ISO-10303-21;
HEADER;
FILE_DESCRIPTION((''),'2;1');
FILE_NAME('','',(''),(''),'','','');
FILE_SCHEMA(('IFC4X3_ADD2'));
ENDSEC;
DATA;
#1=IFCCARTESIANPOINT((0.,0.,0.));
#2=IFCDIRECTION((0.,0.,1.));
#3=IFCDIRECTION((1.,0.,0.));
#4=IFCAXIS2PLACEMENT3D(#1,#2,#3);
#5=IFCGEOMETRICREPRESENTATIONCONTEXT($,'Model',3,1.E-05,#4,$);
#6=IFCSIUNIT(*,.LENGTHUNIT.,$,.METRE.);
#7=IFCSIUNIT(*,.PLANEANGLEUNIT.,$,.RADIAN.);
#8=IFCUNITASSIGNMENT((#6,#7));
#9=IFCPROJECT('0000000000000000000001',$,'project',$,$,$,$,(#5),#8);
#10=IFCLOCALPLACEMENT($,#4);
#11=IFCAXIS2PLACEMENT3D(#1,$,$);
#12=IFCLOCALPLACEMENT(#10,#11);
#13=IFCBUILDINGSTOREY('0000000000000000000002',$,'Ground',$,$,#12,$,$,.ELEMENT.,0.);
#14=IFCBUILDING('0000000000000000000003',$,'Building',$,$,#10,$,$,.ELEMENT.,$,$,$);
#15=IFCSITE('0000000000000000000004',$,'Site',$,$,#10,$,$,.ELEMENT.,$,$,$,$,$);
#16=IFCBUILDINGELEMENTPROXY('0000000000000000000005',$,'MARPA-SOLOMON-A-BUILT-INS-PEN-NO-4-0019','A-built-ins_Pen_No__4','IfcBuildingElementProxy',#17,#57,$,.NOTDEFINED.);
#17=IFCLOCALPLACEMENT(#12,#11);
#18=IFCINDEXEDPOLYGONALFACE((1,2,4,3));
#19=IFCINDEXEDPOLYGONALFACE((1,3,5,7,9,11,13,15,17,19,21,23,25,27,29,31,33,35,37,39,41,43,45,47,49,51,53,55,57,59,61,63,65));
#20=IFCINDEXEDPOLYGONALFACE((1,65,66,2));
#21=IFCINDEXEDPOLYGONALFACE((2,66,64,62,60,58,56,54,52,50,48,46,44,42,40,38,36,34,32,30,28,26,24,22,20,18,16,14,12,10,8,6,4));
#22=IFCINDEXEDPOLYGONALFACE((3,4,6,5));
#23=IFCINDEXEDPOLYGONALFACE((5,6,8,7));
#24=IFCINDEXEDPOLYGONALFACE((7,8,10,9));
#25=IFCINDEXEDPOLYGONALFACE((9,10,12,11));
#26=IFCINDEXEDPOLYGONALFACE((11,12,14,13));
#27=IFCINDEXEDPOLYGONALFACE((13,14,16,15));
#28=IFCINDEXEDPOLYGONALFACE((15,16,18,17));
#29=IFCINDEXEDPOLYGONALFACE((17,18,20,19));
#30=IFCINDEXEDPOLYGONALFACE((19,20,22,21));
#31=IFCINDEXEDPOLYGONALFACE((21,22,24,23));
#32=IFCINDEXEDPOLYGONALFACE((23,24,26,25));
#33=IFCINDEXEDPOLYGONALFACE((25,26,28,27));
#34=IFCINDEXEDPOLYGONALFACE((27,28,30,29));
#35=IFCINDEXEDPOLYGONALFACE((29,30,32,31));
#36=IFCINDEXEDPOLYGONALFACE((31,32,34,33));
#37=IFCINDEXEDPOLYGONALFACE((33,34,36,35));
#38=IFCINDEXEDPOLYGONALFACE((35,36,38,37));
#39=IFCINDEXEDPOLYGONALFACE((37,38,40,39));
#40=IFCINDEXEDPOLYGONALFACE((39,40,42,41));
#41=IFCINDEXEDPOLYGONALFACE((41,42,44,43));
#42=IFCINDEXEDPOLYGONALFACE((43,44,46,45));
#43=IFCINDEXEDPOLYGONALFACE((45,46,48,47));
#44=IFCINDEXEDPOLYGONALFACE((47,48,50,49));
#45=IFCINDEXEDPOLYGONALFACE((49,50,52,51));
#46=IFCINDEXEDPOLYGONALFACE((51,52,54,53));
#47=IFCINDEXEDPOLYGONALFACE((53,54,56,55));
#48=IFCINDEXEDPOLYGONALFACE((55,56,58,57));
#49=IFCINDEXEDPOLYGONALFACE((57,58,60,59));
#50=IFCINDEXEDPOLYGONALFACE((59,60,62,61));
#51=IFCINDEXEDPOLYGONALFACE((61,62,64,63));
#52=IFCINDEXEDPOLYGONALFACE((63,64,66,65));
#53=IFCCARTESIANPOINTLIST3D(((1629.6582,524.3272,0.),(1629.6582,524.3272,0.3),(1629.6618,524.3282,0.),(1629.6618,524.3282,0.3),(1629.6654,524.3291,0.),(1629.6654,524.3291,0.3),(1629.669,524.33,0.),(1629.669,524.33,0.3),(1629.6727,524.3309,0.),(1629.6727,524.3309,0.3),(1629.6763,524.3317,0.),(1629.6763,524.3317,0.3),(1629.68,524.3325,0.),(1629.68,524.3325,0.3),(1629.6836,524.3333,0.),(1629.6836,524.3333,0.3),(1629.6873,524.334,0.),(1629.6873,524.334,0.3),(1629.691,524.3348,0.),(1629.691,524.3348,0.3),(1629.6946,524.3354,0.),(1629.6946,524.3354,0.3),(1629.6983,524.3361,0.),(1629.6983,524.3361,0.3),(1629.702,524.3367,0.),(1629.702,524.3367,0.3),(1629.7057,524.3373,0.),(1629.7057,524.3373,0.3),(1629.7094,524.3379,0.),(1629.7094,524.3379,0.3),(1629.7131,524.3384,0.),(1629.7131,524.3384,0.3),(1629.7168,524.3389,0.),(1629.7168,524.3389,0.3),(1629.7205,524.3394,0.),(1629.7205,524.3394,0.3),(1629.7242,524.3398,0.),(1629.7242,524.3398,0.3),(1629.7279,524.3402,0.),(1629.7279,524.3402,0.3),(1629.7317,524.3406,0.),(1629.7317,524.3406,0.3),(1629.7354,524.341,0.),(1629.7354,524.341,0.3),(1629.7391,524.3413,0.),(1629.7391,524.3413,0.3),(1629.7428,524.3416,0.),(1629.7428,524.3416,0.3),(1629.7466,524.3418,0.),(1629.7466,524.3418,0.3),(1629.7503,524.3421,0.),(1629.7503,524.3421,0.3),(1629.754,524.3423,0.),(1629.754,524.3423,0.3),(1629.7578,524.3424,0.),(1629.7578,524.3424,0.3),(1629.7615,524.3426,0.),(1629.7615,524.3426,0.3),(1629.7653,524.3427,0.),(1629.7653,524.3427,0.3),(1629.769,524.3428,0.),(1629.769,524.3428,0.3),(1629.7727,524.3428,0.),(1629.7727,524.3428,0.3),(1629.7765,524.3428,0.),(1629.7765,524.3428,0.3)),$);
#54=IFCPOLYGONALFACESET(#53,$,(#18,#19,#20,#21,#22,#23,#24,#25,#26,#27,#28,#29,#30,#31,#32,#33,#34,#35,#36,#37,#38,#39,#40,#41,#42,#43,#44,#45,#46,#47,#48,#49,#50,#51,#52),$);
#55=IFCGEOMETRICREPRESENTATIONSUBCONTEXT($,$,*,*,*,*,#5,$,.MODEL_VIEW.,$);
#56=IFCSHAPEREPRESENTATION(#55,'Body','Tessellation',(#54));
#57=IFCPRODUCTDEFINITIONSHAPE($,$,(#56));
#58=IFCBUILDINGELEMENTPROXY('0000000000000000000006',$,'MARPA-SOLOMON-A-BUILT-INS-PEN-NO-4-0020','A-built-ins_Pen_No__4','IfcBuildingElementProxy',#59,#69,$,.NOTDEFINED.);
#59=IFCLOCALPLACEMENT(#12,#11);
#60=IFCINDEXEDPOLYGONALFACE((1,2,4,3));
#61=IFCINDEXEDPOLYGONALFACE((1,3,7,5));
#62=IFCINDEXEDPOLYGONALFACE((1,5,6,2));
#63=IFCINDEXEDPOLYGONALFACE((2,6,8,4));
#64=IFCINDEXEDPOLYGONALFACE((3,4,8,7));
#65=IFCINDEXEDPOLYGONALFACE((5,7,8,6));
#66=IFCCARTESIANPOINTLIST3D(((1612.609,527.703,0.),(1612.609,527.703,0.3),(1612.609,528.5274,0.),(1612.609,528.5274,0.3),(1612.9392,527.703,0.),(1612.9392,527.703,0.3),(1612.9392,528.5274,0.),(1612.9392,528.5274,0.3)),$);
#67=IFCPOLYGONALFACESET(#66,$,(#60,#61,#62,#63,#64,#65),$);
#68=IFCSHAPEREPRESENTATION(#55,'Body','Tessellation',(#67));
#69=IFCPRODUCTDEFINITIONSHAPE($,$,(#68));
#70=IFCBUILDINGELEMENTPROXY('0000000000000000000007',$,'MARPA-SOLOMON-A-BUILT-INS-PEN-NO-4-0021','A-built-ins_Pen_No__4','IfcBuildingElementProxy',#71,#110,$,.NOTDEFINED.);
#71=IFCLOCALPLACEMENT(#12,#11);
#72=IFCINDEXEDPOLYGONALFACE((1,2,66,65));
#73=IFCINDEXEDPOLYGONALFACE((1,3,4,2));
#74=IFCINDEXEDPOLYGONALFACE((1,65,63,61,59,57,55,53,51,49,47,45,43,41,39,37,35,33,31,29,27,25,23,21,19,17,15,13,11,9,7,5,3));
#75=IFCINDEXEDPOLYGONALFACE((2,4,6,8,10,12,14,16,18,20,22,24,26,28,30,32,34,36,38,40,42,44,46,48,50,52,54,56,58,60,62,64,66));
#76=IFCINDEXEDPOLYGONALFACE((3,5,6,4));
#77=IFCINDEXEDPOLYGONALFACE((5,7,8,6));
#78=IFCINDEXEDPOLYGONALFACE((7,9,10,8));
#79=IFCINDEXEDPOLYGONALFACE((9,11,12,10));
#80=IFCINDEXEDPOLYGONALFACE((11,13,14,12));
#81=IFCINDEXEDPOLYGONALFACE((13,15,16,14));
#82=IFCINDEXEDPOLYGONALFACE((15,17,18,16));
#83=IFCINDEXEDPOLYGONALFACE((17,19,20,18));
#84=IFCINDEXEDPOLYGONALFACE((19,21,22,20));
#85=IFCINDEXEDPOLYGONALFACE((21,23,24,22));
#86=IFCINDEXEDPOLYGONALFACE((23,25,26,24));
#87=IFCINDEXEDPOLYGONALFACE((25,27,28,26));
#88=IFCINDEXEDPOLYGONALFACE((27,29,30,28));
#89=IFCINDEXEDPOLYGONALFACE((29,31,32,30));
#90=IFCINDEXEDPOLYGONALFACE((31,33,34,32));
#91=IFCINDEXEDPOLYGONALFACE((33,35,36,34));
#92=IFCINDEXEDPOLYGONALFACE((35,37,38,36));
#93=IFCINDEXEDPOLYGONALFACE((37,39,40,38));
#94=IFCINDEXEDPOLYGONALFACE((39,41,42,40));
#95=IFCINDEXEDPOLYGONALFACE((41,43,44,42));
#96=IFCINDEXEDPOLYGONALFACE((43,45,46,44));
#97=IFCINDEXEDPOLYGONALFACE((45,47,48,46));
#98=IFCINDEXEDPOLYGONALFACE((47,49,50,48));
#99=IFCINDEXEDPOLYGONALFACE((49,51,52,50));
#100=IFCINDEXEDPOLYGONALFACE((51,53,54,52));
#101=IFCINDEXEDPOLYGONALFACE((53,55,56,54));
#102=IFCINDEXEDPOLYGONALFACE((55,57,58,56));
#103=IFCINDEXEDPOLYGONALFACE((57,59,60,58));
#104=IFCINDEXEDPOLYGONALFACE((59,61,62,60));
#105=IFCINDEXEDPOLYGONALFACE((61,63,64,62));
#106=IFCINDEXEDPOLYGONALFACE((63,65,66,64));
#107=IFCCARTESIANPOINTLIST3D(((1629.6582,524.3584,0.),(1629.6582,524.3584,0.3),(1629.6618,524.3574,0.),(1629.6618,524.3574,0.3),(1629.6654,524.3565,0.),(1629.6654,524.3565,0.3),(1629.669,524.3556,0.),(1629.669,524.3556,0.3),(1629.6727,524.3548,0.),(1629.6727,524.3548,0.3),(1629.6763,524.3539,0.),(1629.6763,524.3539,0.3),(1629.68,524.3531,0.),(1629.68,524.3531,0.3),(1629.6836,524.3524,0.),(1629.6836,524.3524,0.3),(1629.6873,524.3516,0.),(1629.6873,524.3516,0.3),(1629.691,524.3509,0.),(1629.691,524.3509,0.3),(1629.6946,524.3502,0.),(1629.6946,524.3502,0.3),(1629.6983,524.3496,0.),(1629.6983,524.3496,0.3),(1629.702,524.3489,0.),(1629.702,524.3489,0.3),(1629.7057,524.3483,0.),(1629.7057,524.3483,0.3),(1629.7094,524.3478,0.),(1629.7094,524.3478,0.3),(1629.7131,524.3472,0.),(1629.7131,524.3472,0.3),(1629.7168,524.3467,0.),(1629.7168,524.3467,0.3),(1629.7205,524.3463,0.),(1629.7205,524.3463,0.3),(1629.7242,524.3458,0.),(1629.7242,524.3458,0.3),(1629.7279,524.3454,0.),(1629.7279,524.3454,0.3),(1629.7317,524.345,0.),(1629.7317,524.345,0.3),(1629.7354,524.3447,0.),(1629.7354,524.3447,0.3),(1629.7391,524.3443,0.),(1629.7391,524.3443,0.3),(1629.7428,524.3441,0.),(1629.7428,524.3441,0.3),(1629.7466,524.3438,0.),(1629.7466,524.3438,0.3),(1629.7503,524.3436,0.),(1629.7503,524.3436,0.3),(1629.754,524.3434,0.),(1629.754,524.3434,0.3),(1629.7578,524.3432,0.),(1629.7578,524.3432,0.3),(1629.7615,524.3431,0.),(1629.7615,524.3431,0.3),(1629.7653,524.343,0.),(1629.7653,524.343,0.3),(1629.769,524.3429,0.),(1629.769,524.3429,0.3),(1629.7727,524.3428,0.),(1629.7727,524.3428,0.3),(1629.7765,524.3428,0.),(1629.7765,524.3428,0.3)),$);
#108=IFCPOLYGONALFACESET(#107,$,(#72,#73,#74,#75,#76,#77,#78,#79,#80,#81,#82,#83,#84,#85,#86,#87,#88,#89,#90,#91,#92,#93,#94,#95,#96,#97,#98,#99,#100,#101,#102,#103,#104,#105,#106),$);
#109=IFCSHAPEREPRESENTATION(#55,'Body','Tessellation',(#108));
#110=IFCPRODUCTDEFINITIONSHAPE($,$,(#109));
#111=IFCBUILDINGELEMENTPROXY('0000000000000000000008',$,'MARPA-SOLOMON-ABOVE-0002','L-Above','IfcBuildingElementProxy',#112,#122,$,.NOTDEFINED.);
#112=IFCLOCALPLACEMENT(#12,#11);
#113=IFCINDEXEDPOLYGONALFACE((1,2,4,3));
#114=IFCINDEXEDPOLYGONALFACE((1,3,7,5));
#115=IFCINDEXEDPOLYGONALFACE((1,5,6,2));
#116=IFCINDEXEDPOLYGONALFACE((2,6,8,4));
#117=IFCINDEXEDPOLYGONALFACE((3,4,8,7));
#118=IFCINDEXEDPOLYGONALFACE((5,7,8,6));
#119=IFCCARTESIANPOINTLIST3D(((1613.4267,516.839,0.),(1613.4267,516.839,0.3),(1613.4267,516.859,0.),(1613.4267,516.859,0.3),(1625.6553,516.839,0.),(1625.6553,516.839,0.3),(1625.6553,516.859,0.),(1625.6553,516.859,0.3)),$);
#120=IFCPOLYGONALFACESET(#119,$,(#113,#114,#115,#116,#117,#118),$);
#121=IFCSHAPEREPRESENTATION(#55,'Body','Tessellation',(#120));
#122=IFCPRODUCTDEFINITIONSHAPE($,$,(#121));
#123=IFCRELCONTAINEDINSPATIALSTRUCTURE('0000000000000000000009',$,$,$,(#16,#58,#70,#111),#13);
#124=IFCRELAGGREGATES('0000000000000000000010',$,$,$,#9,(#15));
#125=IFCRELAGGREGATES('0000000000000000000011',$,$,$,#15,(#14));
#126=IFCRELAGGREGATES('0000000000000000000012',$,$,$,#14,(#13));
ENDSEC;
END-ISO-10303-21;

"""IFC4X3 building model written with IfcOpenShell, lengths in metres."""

from ifc_helpers import new_model, si_unit, frame, frame_2d, origin, origin_with_axes, place, context, subcontext, project, spatial, polyline, rectangle, outline, extrude, element, save


model = new_model("IFC4X3")

# Units and contexts
model_context = context("Model", 3, precision=1e-05, world=origin_with_axes())
sub_context = subcontext(model_context, None, None, "MODEL_VIEW")
ifc_project = project(units=[si_unit("LENGTHUNIT", "METRE"), si_unit("PLANEANGLEUNIT", "RADIAN")], contexts=[model_context])

# Site, building, storey
placement = place(None, origin_with_axes())
site = spatial("IfcSite", under=ifc_project, at=placement, Name="Site", CompositionType="ELEMENT")
building = spatial("IfcBuilding", under=site, at=placement, Name="Building", CompositionType="ELEMENT")
storey_placement = place(placement, origin())
storey = spatial("IfcBuildingStorey", under=building, at=storey_placement, Name="Ground", CompositionType="ELEMENT", Elevation=0.0)

# Building element proxies
proxy_1_placement = place(placement, frame((1629.6582, 524.3272, 0.0)))
element("IfcBuildingElementProxy", 1, at=proxy_1_placement, inside=storey, Name="MARPA-SOLOMON-A-BUILT-INS-PEN-NO-4-0019", Description="A-built-ins_Pen_No__4", ObjectType="IfcBuildingElementProxy", PredefinedType="NOTDEFINED", context=sub_context, shape_type="SweptSolid", body=[
    extrude(outline(polyline([(0.0, 0.0), (0.0036, 0.001), (0.0072, 0.0019), (0.0109, 0.0028), (0.0145, 0.0036), (0.0182, 0.0045), (0.0218, 0.0053), (0.0255, 0.006), (0.0291, 0.0068), (0.0328, 0.0075), (0.0365, 0.0082), (0.0402, 0.0088), (0.0439, 0.0095), (0.0475, 0.0101), (0.0512, 0.0106), (0.0549, 0.0112), (0.0587, 0.0117), (0.0624, 0.0121), (0.0661, 0.0126), (0.0698, 0.013), (0.0735, 0.0134), (0.0772, 0.0137), (0.081, 0.014), (0.0847, 0.0143), (0.0884, 0.0146), (0.0922, 0.0148), (0.0959, 0.015), (0.0996, 0.0152), (0.1034, 0.0153), (0.1071, 0.0154), (0.1109, 0.0155), (0.1146, 0.0156), (0.1183, 0.0156), (0.0, 0.0)])), origin(), (0.0, 0.0, 1.0), 0.3),
])
proxy_2_placement = place(placement, frame((1612.609, 527.703, 0.0)))
element("IfcBuildingElementProxy", 2, at=proxy_2_placement, inside=storey, Name="MARPA-SOLOMON-A-BUILT-INS-PEN-NO-4-0020", Description="A-built-ins_Pen_No__4", ObjectType="IfcBuildingElementProxy", PredefinedType="NOTDEFINED", context=sub_context, shape_type="SweptSolid", body=[
    extrude(outline(polyline([(0.3302, 0.8244), (0.3302, 0.0), (0.0, 0.0), (0.0, 0.8244), (0.3302, 0.8244)])), origin(), (0.0, 0.0, 1.0), 0.3),
])
proxy_3_placement = place(placement, frame((1629.6582, 524.3428, 0.0)))
element("IfcBuildingElementProxy", 3, at=proxy_3_placement, inside=storey, Name="MARPA-SOLOMON-A-BUILT-INS-PEN-NO-4-0021", Description="A-built-ins_Pen_No__4", ObjectType="IfcBuildingElementProxy", PredefinedType="NOTDEFINED", context=sub_context, shape_type="SweptSolid", body=[
    extrude(outline(polyline([(0.1183, 0.0), (0.1146, 0.0), (0.1109, 0.0001), (0.1071, 0.0001), (0.1034, 0.0002), (0.0996, 0.0004), (0.0959, 0.0006), (0.0922, 0.0007), (0.0884, 0.001), (0.0847, 0.0012), (0.081, 0.0015), (0.0772, 0.0019), (0.0735, 0.0022), (0.0698, 0.0026), (0.0661, 0.003), (0.0624, 0.0034), (0.0587, 0.0039), (0.0549, 0.0044), (0.0512, 0.0049), (0.0475, 0.0055), (0.0439, 0.0061), (0.0402, 0.0067), (0.0365, 0.0074), (0.0328, 0.0081), (0.0291, 0.0088), (0.0255, 0.0095), (0.0218, 0.0103), (0.0182, 0.0111), (0.0145, 0.0119), (0.0109, 0.0128), (0.0072, 0.0137), (0.0036, 0.0146), (0.0, 0.0156), (0.1183, 0.0)])), origin(), (0.0, 0.0, 1.0), 0.3),
])
proxy_4_placement = place(placement, frame((1613.4267, 516.839, 0.0)))
element("IfcBuildingElementProxy", 4, at=proxy_4_placement, inside=storey, Name="MARPA-SOLOMON-ABOVE-0002", Description="L-Above", ObjectType="IfcBuildingElementProxy", PredefinedType="NOTDEFINED", context=sub_context, shape_type="SweptSolid", body=[
    extrude(rectangle(XDim=12.2286, YDim=0.02, at=frame_2d((6.1143, 0.01))), origin(), (0.0, 0.0, 1.0), 0.3),
])

save(model, "model.ifc")
